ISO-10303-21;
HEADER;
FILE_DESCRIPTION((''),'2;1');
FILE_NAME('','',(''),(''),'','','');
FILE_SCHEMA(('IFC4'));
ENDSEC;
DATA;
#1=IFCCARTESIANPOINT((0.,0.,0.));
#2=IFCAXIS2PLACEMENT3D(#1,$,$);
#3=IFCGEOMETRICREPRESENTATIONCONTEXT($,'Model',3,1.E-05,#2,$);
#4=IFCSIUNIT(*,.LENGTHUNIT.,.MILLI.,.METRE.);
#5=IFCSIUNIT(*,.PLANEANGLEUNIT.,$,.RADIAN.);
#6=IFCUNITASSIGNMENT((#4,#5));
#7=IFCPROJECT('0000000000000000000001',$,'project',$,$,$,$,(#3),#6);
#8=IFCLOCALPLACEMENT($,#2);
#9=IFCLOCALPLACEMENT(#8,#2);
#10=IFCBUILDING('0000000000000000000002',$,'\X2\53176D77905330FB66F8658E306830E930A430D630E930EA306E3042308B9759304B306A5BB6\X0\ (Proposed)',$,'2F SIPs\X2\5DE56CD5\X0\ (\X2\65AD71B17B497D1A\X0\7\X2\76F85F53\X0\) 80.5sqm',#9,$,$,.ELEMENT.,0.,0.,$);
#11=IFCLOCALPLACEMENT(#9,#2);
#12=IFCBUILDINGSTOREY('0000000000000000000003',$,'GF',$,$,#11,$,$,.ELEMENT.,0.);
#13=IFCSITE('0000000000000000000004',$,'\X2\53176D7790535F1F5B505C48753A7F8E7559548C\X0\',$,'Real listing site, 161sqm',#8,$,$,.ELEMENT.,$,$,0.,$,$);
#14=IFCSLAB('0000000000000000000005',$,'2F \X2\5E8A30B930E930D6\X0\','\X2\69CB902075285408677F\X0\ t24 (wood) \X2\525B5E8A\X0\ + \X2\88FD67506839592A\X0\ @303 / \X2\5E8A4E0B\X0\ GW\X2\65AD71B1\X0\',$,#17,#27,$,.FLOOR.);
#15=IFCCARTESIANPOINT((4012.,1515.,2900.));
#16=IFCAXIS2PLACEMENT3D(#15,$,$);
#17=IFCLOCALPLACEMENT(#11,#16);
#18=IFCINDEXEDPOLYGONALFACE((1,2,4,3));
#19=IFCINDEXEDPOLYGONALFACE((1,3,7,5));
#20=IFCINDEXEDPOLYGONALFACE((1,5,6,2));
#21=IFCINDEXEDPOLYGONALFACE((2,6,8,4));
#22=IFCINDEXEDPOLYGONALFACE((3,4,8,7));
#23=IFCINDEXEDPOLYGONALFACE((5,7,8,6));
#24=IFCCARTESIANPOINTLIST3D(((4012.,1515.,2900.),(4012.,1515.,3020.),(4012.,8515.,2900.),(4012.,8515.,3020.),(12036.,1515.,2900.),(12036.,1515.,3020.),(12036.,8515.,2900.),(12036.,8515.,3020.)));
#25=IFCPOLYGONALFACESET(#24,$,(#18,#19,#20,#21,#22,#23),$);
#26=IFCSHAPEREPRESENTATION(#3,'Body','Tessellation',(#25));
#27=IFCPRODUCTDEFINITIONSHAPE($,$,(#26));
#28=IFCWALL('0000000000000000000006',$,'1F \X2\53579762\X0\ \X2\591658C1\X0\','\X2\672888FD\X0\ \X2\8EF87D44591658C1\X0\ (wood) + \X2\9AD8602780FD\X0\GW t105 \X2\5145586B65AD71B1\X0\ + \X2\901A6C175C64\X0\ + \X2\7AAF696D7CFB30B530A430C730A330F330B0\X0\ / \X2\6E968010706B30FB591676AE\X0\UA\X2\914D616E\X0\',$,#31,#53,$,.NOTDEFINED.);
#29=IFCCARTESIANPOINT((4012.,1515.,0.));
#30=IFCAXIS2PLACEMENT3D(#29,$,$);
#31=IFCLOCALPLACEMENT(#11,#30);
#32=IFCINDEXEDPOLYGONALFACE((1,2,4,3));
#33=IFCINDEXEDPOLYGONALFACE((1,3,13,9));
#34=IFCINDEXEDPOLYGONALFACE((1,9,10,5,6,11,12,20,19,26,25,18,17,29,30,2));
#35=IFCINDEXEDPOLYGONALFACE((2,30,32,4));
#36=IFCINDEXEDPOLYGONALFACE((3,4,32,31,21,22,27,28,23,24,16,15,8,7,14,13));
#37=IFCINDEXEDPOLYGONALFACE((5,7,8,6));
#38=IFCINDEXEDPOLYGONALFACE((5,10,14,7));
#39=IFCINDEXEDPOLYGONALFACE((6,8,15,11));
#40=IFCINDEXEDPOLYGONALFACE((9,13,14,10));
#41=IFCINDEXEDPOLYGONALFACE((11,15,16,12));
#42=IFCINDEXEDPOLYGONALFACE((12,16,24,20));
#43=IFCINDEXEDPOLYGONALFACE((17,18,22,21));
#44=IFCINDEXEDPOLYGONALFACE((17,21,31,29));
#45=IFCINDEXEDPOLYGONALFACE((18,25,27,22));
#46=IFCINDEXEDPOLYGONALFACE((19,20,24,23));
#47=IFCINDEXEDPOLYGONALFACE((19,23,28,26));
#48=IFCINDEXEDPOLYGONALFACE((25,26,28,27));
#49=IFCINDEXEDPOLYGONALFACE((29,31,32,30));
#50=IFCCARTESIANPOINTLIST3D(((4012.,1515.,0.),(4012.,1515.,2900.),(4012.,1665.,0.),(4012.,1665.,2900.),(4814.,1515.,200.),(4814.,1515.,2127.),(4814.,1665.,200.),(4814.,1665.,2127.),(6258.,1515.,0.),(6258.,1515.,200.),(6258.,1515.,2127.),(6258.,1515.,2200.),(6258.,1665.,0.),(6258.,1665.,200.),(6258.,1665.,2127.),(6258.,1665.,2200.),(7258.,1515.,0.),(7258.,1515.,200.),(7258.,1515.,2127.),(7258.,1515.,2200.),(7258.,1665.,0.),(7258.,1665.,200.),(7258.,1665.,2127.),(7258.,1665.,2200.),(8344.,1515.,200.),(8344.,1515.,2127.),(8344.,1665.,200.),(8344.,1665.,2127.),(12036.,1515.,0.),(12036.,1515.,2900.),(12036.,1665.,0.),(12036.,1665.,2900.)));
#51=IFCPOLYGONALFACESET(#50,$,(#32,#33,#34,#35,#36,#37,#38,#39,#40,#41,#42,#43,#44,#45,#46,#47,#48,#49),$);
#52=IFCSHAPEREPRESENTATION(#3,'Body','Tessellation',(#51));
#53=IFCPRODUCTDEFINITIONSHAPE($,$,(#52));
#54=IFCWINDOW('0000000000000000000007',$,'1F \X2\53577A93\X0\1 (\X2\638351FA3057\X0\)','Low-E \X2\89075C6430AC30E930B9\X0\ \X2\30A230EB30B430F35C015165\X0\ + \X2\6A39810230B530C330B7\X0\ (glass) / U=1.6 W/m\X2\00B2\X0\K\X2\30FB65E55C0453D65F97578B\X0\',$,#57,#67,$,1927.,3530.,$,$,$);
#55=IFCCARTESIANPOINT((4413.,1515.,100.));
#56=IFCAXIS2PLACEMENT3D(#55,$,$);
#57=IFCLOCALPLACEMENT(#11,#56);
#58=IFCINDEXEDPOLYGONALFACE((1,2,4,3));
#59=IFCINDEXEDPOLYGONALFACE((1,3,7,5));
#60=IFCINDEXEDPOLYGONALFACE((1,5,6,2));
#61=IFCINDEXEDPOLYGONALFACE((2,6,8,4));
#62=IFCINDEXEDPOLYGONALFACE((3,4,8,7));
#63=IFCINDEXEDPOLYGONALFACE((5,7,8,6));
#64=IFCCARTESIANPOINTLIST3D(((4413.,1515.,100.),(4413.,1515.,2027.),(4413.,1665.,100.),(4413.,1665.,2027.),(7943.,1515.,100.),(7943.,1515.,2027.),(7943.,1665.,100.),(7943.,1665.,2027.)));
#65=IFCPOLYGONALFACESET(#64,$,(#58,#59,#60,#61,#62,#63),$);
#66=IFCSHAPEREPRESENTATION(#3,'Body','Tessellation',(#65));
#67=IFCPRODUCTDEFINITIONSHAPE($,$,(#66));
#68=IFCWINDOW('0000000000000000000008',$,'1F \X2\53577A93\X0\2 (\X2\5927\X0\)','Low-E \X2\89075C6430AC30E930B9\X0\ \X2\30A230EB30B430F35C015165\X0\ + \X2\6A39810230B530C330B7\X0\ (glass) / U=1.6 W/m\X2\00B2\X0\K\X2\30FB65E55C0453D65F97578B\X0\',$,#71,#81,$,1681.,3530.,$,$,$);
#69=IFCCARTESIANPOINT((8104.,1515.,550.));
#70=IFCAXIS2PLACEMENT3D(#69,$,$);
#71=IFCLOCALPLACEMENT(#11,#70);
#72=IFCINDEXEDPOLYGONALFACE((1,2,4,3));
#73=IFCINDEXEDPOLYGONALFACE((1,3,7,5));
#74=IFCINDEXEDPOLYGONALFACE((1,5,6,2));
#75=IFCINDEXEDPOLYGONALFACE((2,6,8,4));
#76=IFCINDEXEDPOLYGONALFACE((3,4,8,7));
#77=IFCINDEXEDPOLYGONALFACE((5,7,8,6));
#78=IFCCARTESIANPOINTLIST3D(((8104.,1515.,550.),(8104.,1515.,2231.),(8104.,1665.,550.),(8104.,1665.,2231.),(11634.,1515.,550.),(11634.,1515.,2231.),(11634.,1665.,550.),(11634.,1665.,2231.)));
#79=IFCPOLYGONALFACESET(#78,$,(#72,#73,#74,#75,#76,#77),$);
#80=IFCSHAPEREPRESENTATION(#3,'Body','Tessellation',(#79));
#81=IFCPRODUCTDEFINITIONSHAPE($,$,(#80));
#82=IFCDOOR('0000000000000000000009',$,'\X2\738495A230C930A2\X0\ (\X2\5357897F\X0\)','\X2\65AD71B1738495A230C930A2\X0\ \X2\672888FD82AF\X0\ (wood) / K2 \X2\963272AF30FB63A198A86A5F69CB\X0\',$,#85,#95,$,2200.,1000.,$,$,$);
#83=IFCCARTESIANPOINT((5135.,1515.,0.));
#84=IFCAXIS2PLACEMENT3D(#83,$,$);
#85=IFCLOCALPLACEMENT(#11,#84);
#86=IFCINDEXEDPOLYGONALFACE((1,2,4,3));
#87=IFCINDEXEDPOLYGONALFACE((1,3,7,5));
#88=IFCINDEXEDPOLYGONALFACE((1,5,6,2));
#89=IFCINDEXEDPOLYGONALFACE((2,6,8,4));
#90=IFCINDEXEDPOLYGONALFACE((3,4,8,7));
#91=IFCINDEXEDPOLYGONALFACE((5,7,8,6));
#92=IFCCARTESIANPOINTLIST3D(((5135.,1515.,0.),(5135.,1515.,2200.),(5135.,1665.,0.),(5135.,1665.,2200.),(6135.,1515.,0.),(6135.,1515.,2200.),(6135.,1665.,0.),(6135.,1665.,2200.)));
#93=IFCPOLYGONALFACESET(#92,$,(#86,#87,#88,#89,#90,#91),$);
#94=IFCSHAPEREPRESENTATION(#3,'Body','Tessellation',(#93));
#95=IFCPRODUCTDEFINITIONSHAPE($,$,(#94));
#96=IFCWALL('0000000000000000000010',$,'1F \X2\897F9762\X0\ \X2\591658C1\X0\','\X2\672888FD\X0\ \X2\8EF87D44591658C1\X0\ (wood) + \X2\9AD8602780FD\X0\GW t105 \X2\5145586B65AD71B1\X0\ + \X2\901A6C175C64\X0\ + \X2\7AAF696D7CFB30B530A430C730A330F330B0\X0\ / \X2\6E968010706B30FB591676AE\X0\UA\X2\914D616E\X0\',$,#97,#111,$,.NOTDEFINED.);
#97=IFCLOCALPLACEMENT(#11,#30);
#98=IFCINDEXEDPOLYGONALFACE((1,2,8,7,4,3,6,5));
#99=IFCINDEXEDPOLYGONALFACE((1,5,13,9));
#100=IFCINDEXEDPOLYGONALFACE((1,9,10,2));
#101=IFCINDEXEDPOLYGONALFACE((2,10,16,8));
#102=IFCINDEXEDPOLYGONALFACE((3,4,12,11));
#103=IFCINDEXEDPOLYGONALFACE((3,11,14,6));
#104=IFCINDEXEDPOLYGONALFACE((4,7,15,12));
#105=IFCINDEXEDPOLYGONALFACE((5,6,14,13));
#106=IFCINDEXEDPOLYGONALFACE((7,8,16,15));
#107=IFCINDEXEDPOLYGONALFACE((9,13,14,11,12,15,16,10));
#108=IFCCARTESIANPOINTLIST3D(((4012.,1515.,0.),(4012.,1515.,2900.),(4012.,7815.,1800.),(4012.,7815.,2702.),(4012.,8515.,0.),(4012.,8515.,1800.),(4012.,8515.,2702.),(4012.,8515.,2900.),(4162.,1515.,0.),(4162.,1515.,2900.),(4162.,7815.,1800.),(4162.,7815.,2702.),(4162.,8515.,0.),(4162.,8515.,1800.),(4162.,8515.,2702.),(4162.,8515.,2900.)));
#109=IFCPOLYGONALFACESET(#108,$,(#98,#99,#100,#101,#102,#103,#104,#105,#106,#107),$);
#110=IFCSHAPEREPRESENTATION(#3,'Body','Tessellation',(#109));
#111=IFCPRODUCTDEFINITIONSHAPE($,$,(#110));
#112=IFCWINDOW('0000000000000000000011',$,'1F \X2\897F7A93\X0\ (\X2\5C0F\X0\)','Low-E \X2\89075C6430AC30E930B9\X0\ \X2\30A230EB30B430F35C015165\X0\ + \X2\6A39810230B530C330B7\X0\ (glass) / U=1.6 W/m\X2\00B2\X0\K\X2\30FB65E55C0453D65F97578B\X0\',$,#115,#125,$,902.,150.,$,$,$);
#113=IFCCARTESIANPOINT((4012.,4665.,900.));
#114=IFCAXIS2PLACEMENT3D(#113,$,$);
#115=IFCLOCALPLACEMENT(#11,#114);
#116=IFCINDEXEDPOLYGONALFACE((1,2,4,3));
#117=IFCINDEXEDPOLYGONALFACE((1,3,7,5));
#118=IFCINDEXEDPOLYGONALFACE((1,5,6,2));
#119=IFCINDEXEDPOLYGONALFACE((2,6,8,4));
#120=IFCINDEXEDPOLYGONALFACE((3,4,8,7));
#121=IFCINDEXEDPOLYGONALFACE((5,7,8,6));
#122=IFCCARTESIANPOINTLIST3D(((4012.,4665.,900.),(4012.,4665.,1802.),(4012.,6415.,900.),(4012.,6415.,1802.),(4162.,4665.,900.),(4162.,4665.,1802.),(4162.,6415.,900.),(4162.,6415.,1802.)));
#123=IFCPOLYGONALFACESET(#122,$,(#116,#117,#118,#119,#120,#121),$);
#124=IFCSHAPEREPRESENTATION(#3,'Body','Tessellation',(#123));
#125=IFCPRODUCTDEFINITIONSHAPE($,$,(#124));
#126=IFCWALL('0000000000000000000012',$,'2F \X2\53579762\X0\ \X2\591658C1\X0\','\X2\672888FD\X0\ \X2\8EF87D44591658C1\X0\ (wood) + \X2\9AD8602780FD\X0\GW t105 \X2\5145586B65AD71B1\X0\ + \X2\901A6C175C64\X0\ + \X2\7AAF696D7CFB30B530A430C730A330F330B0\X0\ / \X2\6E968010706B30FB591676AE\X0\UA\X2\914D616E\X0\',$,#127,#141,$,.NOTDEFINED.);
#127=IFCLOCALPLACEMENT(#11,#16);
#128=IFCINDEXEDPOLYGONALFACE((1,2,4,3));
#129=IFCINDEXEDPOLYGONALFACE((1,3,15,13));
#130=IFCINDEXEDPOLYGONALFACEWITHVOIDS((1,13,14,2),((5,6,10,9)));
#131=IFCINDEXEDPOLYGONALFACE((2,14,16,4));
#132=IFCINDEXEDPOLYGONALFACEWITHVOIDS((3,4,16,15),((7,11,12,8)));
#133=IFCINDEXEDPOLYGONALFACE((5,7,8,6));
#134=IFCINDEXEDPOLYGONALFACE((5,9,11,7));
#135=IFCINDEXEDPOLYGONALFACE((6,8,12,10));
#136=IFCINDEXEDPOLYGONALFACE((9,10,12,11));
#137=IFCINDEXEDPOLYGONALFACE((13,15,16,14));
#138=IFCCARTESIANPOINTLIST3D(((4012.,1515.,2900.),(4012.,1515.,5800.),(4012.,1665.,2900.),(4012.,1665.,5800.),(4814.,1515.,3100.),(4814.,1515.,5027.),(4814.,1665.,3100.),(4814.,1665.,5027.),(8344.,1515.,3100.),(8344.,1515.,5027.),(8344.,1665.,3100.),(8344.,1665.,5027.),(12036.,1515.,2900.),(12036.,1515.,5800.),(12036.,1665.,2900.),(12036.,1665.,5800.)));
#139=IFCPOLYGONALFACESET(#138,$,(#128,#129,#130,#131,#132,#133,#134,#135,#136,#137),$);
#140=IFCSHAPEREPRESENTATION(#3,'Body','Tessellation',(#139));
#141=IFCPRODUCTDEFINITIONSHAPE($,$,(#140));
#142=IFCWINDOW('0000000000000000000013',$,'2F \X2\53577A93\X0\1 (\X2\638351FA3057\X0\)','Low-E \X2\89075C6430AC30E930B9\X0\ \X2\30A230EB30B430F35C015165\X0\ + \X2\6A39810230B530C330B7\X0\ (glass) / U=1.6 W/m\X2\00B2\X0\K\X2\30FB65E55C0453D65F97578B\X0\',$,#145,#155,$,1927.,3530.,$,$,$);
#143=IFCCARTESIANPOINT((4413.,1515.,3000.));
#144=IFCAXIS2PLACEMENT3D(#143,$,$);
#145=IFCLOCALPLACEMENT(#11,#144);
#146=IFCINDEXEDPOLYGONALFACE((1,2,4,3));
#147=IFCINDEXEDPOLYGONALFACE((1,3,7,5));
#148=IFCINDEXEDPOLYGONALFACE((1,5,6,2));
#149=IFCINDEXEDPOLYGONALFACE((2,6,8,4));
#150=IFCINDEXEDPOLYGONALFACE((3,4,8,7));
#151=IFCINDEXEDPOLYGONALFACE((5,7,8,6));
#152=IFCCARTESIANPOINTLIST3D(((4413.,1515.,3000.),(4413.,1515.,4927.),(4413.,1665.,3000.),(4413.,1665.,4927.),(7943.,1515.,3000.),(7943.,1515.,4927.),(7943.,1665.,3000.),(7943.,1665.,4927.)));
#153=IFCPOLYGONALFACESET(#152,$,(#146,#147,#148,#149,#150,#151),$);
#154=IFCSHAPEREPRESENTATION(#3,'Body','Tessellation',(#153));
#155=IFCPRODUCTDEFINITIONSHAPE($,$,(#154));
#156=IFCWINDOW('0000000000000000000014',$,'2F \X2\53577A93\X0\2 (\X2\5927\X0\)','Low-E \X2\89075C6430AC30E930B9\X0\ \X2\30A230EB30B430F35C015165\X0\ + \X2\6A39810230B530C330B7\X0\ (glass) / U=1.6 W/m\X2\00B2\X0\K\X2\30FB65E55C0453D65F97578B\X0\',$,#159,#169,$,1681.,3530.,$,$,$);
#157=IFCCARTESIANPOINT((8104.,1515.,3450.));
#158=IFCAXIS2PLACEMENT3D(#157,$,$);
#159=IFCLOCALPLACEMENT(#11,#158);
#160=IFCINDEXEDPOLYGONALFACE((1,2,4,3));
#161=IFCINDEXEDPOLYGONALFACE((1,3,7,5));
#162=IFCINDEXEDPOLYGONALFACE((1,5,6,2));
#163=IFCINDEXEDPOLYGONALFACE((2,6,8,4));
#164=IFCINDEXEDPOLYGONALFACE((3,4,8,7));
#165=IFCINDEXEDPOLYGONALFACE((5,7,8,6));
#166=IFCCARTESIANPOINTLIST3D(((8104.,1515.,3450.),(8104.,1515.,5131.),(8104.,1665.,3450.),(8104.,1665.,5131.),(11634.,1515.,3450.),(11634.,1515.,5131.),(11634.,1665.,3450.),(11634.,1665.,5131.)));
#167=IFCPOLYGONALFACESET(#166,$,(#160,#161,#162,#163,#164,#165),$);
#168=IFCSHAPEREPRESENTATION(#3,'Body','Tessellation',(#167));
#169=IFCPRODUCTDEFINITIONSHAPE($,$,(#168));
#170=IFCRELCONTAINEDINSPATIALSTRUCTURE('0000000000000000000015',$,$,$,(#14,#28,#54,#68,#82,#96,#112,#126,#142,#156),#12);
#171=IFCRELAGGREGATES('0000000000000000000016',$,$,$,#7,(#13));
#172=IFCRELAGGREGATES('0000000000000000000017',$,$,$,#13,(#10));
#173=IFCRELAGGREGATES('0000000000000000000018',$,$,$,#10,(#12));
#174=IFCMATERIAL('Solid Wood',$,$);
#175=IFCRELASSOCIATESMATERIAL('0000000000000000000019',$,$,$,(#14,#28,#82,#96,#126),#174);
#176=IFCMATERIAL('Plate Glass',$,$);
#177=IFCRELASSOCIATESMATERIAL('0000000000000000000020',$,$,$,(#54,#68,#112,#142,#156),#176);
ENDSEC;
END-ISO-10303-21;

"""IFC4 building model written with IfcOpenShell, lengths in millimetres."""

from ifc_helpers import new_model, si_unit, frame, frame_2d, origin, place, context, project, spatial, rectangle, extrude, material, element, fill, save


model = new_model("IFC4")

# Units and contexts
model_context = context("Model", 3, precision=1e-05, world=origin())
ifc_project = project(units=[si_unit("LENGTHUNIT", "METRE", prefix="MILLI"), si_unit("PLANEANGLEUNIT", "RADIAN")], contexts=[model_context])

# Site, building, storey
site_placement = place(None, origin())
site = spatial("IfcSite", under=ifc_project, at=site_placement, Name="北海道弟子屈町美留和", ObjectType="Real listing site, 161sqm", CompositionType="ELEMENT", RefElevation=0.0)
building_placement = place(site_placement, origin())
building = spatial("IfcBuilding", under=site, at=building_placement, Name="北海道・書斎とライブラリのある静かな家 (Proposed)", ObjectType="2F SIPs工法 (断熱等級7相当) 80.5sqm", CompositionType="ELEMENT", ElevationOfRefHeight=0.0, ElevationOfTerrain=0.0)
storey_placement = place(building_placement, origin())
storey = spatial("IfcBuildingStorey", under=building, at=storey_placement, Name="GF", CompositionType="ELEMENT", Elevation=0.0)

# Slab
ifc_material_1 = material(Name="Solid Wood")
slab_1_placement = place(storey_placement, frame((4012.0, 1515.0, 2900.0)))
element("IfcSlab", 1, at=slab_1_placement, inside=storey, material=ifc_material_1, Name="2F 床スラブ", Description="構造用合板 t24 (wood) 剛床 + 製材根太 @303 / 床下 GW断熱", PredefinedType="FLOOR", context=model_context, shape_type="SweptSolid", body=[
    extrude(rectangle(XDim=8024.0, YDim=7000.0, at=frame_2d((4012.0, 3500.0))), frame((4012.0, 1515.0, 2900.0)), (0.0, 0.0, 1.0), 120.0),
])

# Wall, openings, windows, door
wall_1_placement = place(storey_placement, frame((4012.0, 1515.0, 0.0)))
wall_1 = element("IfcWall", 2, at=wall_1_placement, inside=storey, material=ifc_material_1, Name="1F 南面 外壁", Description="木製 軸組外壁 (wood) + 高性能GW t105 充填断熱 + 通気層 + 窯業系サイディング / 準耐火・外皮UA配慮", PredefinedType="NOTDEFINED", context=model_context, shape_type="SweptSolid", body=[
    extrude(rectangle(XDim=8024.0, YDim=150.0, at=frame_2d((4012.0, 75.0))), frame((4012.0, 1515.0, 0.0)), (0.0, 0.0, 1.0), 2900.0),
])
opening_1_placement = place(storey_placement, frame((4413.0, 1515.0, 100.0)))
opening_1 = element("IfcOpeningElement", 3, at=opening_1_placement, cuts=wall_1, PredefinedType="NOTDEFINED", context=model_context, shape_type="SweptSolid", body=[
    extrude(rectangle(XDim=3530.0, YDim=150.0, at=frame_2d((1765.0, 75.0))), frame((4413.0, 1515.0, 100.0)), (0.0, 0.0, 1.0), 1927.0),
])
opening_2_placement = place(storey_placement, frame((8104.0, 1515.0, 550.0)))
opening_2 = element("IfcOpeningElement", 4, at=opening_2_placement, cuts=wall_1, PredefinedType="NOTDEFINED", context=model_context, shape_type="SweptSolid", body=[
    extrude(rectangle(XDim=3530.0, YDim=150.0, at=frame_2d((1765.0, 75.0))), frame((8104.0, 1515.0, 550.0)), (0.0, 0.0, 1.0), 1681.0),
])
opening_3_placement = place(storey_placement, frame((5135.0, 1515.0, 0.0)))
opening_3 = element("IfcOpeningElement", 5, at=opening_3_placement, cuts=wall_1, PredefinedType="NOTDEFINED", context=model_context, shape_type="SweptSolid", body=[
    extrude(rectangle(XDim=1000.0, YDim=150.0, at=frame_2d((500.0, 75.0))), frame((5135.0, 1515.0, 0.0)), (0.0, 0.0, 1.0), 2200.0),
])
ifc_material_2 = material(Name="Plate Glass")
window_1_placement = place(storey_placement, frame((4413.0, 1515.0, 100.0)))
window_1 = element("IfcWindow", 6, at=window_1_placement, inside=storey, material=ifc_material_2, Name="1F 南窓1 (掃出し)", Description="Low-E 複層ガラス アルゴン封入 + 樹脂サッシ (glass) / U=1.6 W/m²K・日射取得型", OverallHeight=1927.0, OverallWidth=3530.0, context=model_context, shape_type="SweptSolid", body=[
    extrude(rectangle(XDim=3530.0, YDim=150.0, at=frame_2d((1765.0, 75.0))), frame((4413.0, 1515.0, 100.0)), (0.0, 0.0, 1.0), 1927.0),
])
fill(opening_1, window_1)
window_2_placement = place(storey_placement, frame((8104.0, 1515.0, 550.0)))
window_2 = element("IfcWindow", 7, at=window_2_placement, inside=storey, material=ifc_material_2, Name="1F 南窓2 (大)", Description="Low-E 複層ガラス アルゴン封入 + 樹脂サッシ (glass) / U=1.6 W/m²K・日射取得型", OverallHeight=1681.0, OverallWidth=3530.0, context=model_context, shape_type="SweptSolid", body=[
    extrude(rectangle(XDim=3530.0, YDim=150.0, at=frame_2d((1765.0, 75.0))), frame((8104.0, 1515.0, 550.0)), (0.0, 0.0, 1.0), 1681.0),
])
fill(opening_2, window_2)
door_placement = place(storey_placement, frame((5135.0, 1515.0, 0.0)))
door = element("IfcDoor", 8, at=door_placement, inside=storey, material=ifc_material_1, Name="玄関ドア (南西)", Description="断熱玄関ドア 木製芯 (wood) / K2 防犯・採風機構", OverallHeight=2200.0, OverallWidth=1000.0, context=model_context, shape_type="SweptSolid", body=[
    extrude(rectangle(XDim=1000.0, YDim=150.0, at=frame_2d((500.0, 75.0))), frame((5135.0, 1515.0, 0.0)), (0.0, 0.0, 1.0), 2200.0),
])
fill(opening_3, door)

# Wall, opening, window
wall_2_placement = place(storey_placement, frame((4012.0, 1515.0, 0.0)))
wall_2 = element("IfcWall", 9, at=wall_2_placement, inside=storey, material=ifc_material_1, Name="1F 西面 外壁", Description="木製 軸組外壁 (wood) + 高性能GW t105 充填断熱 + 通気層 + 窯業系サイディング / 準耐火・外皮UA配慮", PredefinedType="NOTDEFINED", context=model_context, shape_type="SweptSolid", body=[
    extrude(rectangle(XDim=150.0, YDim=7000.0, at=frame_2d((75.0, 3500.0))), frame((4012.0, 1515.0, 0.0)), (0.0, 0.0, 1.0), 2900.0),
])
opening_4_placement = place(storey_placement, frame((4012.0, 4665.0, 900.0)))
opening_4 = element("IfcOpeningElement", 10, at=opening_4_placement, cuts=wall_2, PredefinedType="NOTDEFINED", context=model_context, shape_type="SweptSolid", body=[
    extrude(rectangle(XDim=150.0, YDim=1750.0, at=frame_2d((75.0, 875.0))), frame((4012.0, 4665.0, 900.0)), (0.0, 0.0, 1.0), 902.0),
])
window_3_placement = place(storey_placement, frame((4012.0, 4665.0, 900.0)))
window_3 = element("IfcWindow", 11, at=window_3_placement, inside=storey, material=ifc_material_2, Name="1F 西窓 (小)", Description="Low-E 複層ガラス アルゴン封入 + 樹脂サッシ (glass) / U=1.6 W/m²K・日射取得型", OverallHeight=902.0, OverallWidth=150.0, context=model_context, shape_type="SweptSolid", body=[
    extrude(rectangle(XDim=150.0, YDim=1750.0, at=frame_2d((75.0, 875.0))), frame((4012.0, 4665.0, 900.0)), (0.0, 0.0, 1.0), 902.0),
])
fill(opening_4, window_3)

# Wall, openings, windows
wall_3_placement = place(storey_placement, frame((4012.0, 1515.0, 2900.0)))
wall_3 = element("IfcWall", 12, at=wall_3_placement, inside=storey, material=ifc_material_1, Name="2F 南面 外壁", Description="木製 軸組外壁 (wood) + 高性能GW t105 充填断熱 + 通気層 + 窯業系サイディング / 準耐火・外皮UA配慮", PredefinedType="NOTDEFINED", context=model_context, shape_type="SweptSolid", body=[
    extrude(rectangle(XDim=8024.0, YDim=150.0, at=frame_2d((4012.0, 75.0))), frame((4012.0, 1515.0, 2900.0)), (0.0, 0.0, 1.0), 2900.0),
])
opening_5_placement = place(storey_placement, frame((4413.0, 1515.0, 3000.0)))
opening_5 = element("IfcOpeningElement", 13, at=opening_5_placement, cuts=wall_3, PredefinedType="NOTDEFINED", context=model_context, shape_type="SweptSolid", body=[
    extrude(rectangle(XDim=3530.0, YDim=150.0, at=frame_2d((1765.0, 75.0))), frame((4413.0, 1515.0, 3000.0)), (0.0, 0.0, 1.0), 1927.0),
])
opening_6_placement = place(storey_placement, frame((8104.0, 1515.0, 3450.0)))
opening_6 = element("IfcOpeningElement", 14, at=opening_6_placement, cuts=wall_3, PredefinedType="NOTDEFINED", context=model_context, shape_type="SweptSolid", body=[
    extrude(rectangle(XDim=3530.0, YDim=150.0, at=frame_2d((1765.0, 75.0))), frame((8104.0, 1515.0, 3450.0)), (0.0, 0.0, 1.0), 1681.0),
])
window_4_placement = place(storey_placement, frame((4413.0, 1515.0, 3000.0)))
window_4 = element("IfcWindow", 15, at=window_4_placement, inside=storey, material=ifc_material_2, Name="2F 南窓1 (掃出し)", Description="Low-E 複層ガラス アルゴン封入 + 樹脂サッシ (glass) / U=1.6 W/m²K・日射取得型", OverallHeight=1927.0, OverallWidth=3530.0, context=model_context, shape_type="SweptSolid", body=[
    extrude(rectangle(XDim=3530.0, YDim=150.0, at=frame_2d((1765.0, 75.0))), frame((4413.0, 1515.0, 3000.0)), (0.0, 0.0, 1.0), 1927.0),
])
fill(opening_5, window_4)
window_5_placement = place(storey_placement, frame((8104.0, 1515.0, 3450.0)))
window_5 = element("IfcWindow", 16, at=window_5_placement, inside=storey, material=ifc_material_2, Name="2F 南窓2 (大)", Description="Low-E 複層ガラス アルゴン封入 + 樹脂サッシ (glass) / U=1.6 W/m²K・日射取得型", OverallHeight=1681.0, OverallWidth=3530.0, context=model_context, shape_type="SweptSolid", body=[
    extrude(rectangle(XDim=3530.0, YDim=150.0, at=frame_2d((1765.0, 75.0))), frame((8104.0, 1515.0, 3450.0)), (0.0, 0.0, 1.0), 1681.0),
])
fill(opening_6, window_5)

save(model, "model.ifc")
